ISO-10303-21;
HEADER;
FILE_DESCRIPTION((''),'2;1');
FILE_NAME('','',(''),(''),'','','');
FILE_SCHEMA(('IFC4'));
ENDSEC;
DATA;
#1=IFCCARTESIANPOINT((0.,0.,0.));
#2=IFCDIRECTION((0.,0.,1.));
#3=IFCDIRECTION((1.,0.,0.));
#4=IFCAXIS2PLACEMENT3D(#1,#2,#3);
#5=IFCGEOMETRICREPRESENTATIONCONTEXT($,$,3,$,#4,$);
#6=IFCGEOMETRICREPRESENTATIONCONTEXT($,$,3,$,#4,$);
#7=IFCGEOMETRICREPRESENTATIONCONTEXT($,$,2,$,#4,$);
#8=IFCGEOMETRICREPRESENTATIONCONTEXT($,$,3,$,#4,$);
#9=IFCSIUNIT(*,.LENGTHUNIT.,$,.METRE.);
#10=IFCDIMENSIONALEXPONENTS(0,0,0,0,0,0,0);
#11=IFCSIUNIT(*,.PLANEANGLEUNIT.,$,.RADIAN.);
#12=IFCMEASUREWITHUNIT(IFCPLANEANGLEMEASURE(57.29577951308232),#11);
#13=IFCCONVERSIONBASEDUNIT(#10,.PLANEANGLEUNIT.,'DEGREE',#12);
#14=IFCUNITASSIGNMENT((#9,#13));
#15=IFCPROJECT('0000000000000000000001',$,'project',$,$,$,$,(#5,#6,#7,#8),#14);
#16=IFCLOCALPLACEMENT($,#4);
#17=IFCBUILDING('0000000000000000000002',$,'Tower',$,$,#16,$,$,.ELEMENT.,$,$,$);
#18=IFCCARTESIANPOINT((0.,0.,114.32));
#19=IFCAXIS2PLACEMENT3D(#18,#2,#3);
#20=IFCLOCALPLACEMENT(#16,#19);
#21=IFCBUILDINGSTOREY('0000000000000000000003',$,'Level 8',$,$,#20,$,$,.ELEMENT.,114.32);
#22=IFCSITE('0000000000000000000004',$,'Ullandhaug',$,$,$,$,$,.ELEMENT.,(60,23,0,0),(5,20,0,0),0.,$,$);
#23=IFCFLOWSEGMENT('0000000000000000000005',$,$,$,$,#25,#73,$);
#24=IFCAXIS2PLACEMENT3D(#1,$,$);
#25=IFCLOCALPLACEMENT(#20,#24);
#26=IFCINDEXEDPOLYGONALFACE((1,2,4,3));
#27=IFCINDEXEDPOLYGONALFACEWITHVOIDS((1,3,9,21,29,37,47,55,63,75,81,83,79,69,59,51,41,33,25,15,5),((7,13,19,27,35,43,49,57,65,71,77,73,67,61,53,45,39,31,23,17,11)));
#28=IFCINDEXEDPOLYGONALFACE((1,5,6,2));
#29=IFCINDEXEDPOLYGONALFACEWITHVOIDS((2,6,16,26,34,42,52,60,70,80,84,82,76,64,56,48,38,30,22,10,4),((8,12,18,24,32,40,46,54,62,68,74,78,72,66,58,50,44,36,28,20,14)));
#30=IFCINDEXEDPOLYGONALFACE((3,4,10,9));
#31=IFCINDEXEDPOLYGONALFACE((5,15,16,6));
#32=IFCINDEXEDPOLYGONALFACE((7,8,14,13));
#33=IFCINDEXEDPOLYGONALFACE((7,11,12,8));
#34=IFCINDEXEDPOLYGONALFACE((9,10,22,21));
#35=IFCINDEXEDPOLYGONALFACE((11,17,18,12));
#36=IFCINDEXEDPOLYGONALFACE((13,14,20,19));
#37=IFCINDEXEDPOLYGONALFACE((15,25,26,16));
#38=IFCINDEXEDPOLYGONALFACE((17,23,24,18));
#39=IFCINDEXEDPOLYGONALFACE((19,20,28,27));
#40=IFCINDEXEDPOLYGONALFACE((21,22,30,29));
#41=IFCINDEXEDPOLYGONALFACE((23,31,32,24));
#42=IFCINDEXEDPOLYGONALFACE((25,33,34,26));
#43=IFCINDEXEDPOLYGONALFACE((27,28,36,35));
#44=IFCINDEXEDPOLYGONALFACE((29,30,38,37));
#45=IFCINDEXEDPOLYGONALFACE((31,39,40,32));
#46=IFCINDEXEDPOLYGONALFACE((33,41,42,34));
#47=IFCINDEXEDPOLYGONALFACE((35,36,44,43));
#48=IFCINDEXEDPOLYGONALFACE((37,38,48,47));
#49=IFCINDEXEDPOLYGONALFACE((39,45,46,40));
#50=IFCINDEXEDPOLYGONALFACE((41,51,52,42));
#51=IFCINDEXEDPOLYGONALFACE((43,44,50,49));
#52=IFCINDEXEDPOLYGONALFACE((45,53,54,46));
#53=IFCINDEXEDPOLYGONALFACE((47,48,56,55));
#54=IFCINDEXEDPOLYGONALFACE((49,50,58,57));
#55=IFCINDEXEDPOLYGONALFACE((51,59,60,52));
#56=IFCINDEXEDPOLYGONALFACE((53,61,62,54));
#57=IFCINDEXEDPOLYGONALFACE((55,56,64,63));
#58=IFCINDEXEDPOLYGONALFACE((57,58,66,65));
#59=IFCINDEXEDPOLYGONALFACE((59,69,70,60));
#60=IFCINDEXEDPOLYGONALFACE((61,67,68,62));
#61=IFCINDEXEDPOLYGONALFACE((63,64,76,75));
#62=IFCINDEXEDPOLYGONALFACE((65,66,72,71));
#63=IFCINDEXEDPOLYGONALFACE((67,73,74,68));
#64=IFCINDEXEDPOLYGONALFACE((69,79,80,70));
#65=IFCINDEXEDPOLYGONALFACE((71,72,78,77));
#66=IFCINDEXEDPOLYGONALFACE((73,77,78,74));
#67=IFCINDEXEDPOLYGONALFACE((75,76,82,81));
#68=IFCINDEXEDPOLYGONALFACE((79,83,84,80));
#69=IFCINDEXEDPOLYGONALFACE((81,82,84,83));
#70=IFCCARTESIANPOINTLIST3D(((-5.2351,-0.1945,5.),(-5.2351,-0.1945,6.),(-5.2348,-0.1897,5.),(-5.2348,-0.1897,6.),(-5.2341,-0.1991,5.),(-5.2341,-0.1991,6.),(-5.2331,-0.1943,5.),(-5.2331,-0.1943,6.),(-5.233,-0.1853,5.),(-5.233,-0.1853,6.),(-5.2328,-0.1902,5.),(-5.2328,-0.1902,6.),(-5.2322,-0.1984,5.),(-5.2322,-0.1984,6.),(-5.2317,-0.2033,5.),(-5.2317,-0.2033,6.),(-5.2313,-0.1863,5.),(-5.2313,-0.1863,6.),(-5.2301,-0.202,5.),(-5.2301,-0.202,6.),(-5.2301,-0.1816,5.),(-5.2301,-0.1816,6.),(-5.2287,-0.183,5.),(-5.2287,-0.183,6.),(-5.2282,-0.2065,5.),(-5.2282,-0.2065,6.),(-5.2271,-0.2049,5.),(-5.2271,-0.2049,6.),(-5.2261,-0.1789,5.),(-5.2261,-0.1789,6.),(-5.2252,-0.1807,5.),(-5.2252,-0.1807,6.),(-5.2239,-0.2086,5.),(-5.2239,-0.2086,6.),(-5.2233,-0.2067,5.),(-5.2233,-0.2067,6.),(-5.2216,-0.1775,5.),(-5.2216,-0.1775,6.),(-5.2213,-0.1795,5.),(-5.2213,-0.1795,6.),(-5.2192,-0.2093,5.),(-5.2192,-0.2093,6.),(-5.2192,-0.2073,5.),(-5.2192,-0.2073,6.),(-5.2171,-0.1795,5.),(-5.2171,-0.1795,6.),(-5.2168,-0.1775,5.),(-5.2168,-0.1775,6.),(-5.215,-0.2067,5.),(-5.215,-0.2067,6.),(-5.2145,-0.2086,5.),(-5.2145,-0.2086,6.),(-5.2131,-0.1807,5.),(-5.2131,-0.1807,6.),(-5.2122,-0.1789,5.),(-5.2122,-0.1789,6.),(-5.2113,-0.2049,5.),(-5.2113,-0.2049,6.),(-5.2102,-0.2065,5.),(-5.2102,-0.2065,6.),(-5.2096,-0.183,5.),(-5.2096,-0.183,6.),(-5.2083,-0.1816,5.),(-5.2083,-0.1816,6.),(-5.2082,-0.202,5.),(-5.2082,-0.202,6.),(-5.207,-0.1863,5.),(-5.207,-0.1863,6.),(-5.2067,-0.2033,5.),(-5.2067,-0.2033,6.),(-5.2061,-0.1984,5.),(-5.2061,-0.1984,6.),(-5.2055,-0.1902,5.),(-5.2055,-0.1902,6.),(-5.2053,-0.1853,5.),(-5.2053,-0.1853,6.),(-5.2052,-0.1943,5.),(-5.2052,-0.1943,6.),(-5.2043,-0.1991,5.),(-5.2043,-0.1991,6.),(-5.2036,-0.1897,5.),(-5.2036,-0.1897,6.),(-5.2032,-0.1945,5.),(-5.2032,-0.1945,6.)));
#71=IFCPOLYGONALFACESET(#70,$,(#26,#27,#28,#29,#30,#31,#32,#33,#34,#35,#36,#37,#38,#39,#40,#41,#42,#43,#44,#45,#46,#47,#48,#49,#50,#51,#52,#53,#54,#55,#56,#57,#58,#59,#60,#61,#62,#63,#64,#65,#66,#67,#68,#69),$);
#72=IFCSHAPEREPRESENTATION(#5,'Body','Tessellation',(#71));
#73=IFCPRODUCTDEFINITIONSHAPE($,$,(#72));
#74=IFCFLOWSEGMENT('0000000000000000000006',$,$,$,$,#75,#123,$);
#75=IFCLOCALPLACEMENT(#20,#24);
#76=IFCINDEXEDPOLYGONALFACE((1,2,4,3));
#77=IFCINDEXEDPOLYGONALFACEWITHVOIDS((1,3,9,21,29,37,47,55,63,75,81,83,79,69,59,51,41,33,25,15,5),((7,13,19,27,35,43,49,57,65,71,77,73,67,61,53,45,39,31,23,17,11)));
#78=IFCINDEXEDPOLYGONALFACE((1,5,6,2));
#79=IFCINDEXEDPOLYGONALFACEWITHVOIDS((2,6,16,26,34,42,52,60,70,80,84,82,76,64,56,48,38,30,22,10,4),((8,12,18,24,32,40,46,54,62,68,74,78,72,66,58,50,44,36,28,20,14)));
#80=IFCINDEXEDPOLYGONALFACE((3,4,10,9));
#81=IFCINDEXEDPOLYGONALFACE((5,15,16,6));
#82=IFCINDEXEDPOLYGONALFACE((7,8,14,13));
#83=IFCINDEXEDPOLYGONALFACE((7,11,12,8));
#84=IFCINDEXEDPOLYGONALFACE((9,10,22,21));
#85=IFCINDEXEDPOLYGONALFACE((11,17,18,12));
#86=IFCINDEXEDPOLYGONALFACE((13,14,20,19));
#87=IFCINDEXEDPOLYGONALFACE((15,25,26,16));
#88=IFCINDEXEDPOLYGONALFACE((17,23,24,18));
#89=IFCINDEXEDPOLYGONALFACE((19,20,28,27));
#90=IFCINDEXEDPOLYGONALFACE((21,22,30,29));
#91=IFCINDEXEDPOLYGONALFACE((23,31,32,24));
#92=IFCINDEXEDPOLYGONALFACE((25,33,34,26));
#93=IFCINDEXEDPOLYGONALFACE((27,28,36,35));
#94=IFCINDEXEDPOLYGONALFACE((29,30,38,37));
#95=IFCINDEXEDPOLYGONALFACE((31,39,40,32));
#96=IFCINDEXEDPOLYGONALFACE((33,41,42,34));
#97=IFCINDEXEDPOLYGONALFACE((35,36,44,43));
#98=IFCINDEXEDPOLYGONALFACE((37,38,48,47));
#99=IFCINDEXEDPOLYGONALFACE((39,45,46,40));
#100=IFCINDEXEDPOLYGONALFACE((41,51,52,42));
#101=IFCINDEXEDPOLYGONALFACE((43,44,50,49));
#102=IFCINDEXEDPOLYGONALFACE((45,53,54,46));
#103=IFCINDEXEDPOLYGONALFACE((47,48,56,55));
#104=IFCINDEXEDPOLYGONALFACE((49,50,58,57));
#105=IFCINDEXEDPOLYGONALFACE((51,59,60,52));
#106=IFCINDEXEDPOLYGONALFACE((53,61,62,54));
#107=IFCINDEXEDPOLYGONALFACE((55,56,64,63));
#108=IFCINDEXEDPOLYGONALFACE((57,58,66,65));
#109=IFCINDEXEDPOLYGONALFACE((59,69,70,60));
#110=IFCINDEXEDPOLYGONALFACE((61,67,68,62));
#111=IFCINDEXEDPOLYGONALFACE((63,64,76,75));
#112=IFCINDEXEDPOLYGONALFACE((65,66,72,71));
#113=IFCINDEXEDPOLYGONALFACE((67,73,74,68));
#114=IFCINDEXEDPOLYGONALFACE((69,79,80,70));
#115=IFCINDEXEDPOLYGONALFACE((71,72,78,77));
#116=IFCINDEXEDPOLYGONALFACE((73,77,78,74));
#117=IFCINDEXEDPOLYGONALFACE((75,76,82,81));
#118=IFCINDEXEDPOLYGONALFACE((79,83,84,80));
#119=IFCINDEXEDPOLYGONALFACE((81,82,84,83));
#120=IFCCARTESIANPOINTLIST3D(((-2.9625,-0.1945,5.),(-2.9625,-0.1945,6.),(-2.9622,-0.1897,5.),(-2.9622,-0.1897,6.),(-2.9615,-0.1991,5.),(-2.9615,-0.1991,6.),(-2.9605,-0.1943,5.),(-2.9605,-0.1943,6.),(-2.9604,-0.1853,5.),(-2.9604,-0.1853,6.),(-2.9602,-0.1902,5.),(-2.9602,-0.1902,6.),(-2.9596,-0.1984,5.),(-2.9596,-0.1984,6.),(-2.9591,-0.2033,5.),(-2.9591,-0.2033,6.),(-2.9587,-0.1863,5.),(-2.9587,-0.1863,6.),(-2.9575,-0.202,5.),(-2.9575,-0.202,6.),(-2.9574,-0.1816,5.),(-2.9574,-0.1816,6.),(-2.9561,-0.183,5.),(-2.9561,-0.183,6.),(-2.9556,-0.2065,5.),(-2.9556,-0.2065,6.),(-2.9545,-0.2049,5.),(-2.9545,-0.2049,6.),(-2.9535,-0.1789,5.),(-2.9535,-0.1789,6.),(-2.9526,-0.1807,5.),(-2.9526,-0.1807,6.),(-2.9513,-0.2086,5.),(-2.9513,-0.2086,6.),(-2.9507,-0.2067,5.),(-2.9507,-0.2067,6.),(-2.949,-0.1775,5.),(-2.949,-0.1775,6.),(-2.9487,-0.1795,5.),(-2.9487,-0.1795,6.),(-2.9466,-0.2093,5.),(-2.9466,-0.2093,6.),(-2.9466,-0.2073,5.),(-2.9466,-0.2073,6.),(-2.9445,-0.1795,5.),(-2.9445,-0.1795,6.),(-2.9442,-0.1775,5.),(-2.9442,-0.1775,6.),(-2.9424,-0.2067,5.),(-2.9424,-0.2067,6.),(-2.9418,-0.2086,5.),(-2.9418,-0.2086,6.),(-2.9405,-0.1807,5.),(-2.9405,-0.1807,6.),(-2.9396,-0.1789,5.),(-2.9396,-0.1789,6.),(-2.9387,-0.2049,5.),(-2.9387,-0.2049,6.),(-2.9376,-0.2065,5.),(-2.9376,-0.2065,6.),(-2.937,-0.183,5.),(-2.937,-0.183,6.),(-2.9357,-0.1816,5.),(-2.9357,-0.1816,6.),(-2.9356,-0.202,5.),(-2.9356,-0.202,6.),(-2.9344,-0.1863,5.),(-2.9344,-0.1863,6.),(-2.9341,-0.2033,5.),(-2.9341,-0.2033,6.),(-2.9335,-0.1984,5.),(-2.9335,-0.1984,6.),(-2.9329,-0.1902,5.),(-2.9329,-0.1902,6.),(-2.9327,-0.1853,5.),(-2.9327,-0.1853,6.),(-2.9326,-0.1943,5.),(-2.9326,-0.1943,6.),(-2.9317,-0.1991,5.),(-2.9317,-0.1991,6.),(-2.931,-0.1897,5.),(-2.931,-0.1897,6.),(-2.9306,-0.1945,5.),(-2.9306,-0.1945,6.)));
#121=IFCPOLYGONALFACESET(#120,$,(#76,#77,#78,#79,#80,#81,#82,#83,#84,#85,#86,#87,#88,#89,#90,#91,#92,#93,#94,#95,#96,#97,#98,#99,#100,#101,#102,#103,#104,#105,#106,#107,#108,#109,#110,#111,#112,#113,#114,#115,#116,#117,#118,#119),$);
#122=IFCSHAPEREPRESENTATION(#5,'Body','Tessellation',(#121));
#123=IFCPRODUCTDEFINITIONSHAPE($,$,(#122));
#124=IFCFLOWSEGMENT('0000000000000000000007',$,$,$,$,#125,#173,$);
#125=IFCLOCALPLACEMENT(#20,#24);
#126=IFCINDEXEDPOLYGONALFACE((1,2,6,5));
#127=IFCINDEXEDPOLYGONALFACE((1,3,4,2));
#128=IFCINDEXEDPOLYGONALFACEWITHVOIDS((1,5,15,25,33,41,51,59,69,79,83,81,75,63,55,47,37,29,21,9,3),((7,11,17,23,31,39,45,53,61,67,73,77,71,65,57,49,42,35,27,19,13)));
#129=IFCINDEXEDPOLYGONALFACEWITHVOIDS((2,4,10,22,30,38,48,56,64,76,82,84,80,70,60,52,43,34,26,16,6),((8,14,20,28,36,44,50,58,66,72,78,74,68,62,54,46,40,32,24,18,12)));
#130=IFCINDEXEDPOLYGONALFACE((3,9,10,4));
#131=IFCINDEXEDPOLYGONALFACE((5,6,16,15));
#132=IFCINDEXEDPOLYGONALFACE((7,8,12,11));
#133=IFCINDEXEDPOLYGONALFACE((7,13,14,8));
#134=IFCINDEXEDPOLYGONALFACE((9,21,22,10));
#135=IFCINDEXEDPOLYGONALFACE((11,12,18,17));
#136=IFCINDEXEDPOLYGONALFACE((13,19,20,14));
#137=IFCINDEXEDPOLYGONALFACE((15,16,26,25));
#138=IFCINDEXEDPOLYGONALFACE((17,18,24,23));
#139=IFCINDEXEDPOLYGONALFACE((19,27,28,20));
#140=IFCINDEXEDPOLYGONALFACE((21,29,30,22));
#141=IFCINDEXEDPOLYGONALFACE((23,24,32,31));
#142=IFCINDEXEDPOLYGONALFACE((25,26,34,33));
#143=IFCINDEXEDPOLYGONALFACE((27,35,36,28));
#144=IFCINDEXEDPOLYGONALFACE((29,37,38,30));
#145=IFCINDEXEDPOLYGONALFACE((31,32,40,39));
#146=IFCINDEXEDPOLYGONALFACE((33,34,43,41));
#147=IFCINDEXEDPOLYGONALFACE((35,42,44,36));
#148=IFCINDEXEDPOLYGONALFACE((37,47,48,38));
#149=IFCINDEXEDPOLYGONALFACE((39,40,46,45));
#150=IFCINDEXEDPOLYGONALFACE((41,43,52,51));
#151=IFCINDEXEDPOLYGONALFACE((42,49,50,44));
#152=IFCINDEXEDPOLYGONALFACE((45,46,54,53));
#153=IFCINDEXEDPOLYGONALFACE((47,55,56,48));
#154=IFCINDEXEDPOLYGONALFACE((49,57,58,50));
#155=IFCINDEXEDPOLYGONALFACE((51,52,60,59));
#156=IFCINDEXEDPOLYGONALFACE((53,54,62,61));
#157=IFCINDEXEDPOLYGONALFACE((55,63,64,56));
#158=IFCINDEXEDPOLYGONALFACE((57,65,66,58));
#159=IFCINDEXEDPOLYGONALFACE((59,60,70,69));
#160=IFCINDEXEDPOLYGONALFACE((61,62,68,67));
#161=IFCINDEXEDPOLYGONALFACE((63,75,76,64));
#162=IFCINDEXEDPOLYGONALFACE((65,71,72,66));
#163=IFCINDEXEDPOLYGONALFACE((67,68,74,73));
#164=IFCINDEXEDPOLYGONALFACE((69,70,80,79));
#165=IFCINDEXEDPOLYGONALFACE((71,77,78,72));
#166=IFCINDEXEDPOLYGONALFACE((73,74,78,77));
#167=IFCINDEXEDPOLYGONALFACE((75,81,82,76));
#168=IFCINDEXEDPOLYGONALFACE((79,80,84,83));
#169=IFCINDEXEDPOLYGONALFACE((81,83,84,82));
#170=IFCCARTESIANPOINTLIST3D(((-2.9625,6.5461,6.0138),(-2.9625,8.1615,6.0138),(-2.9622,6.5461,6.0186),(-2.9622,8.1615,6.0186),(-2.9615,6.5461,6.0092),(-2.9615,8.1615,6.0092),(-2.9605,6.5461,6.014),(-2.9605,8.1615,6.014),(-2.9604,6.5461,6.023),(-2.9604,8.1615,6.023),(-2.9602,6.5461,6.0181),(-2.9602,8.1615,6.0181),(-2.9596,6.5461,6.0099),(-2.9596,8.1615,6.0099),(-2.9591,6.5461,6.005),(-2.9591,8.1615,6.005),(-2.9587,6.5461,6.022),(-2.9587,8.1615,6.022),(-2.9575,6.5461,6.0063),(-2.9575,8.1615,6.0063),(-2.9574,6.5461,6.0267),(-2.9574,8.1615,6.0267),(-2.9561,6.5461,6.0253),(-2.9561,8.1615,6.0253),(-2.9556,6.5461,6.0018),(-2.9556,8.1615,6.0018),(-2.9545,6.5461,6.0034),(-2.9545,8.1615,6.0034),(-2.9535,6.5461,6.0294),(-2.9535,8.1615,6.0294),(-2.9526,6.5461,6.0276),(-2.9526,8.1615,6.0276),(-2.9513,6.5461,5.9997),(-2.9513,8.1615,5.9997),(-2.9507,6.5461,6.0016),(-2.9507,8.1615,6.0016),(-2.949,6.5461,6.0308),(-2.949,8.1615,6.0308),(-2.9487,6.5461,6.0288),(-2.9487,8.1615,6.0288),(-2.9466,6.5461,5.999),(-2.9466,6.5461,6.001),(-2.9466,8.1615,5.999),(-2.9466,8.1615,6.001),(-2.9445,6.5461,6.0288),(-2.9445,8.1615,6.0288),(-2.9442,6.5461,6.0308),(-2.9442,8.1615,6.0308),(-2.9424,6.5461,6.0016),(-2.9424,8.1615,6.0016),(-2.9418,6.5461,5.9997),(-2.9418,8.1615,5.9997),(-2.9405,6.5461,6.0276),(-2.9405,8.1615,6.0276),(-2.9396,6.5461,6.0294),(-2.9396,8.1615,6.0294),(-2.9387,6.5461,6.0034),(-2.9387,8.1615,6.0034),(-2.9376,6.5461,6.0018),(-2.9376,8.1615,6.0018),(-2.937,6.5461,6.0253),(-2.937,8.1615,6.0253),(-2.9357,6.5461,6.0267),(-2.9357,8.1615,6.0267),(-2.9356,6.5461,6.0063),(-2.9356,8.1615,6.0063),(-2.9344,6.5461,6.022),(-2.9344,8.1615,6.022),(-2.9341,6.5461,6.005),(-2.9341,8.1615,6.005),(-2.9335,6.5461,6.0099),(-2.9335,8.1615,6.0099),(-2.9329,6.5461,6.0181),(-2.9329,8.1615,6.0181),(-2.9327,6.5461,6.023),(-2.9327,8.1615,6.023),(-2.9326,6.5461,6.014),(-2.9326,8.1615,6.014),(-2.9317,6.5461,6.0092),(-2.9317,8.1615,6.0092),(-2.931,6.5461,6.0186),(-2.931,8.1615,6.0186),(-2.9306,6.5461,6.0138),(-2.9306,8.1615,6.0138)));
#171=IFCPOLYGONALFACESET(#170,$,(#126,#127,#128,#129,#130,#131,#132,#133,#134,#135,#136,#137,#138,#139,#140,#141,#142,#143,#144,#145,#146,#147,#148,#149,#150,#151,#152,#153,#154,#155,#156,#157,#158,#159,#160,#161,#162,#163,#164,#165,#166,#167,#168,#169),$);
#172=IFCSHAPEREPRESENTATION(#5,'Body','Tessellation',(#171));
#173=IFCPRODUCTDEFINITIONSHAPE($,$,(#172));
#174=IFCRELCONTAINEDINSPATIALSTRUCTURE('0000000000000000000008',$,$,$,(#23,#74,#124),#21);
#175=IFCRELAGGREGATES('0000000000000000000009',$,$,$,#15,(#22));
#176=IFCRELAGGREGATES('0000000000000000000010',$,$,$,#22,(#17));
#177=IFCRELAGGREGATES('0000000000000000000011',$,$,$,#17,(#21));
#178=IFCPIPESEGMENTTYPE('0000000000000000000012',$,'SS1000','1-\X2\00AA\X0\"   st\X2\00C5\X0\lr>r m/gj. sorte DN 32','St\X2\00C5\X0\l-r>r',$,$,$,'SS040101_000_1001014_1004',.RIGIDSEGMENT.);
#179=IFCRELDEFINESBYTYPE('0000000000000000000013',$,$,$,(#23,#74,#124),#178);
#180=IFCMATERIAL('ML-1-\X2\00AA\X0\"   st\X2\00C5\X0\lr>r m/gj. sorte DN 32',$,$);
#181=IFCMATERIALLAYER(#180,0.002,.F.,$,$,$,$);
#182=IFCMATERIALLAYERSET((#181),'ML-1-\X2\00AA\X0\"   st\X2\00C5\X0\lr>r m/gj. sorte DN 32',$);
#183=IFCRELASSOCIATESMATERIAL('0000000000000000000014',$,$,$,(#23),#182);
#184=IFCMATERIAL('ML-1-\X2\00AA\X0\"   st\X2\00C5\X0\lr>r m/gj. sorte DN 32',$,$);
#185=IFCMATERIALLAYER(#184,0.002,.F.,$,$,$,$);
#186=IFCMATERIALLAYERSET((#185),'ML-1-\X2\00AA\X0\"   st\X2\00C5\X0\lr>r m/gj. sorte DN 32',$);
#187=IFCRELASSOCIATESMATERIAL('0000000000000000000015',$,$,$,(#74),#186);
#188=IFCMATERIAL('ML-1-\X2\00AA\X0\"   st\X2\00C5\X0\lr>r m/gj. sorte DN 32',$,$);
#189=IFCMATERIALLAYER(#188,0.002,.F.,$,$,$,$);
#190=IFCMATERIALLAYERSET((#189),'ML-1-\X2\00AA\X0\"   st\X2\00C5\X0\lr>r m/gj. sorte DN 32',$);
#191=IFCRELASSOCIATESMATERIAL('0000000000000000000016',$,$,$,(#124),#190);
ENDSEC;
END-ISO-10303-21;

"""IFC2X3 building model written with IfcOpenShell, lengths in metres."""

from ifc_helpers import new_model, entity, si_unit, converted_unit, frame, origin_with_axes, origin_2d_with_axis, place, context, project, spatial, hollow_circle, extrude, material, layer, layer_set, layer_usage, type_object, element, save


model = new_model("IFC2X3")

# Units and contexts
context_of_model_1 = context(None, 3, world=origin_with_axes())
context_of_model_2 = context(None, 3, world=origin_with_axes())
context_of_model_3 = context(None, 2, world=origin_with_axes())
context_of_model_4 = context(None, 3, world=origin_with_axes())
ifc_project = project(units=[si_unit("LENGTHUNIT", "METRE"), converted_unit("PLANEANGLEUNIT", "DEGREE", entity("IfcPlaneAngleMeasure", 57.29577951308232), si_unit("PLANEANGLEUNIT", "RADIAN"), dimensions=[0, 0, 0, 0, 0, 0, 0])], contexts=[context_of_model_1, context_of_model_2, context_of_model_3, context_of_model_4])

# Site, building, storey
site = spatial("IfcSite", under=ifc_project, Name="Ullandhaug", CompositionType="ELEMENT", RefLatitude=(60, 23, 0, 0), RefLongitude=(5, 20, 0, 0), RefElevation=0.0)
building_placement = place(None, origin_with_axes())
building = spatial("IfcBuilding", under=site, at=building_placement, Name="Tower", CompositionType="ELEMENT")
storey_placement = place(building_placement, frame((0.0, 0.0, 114.32), z_axis=(0.0, 0.0, 1.0), x_axis=(1.0, 0.0, 0.0)))
storey = spatial("IfcBuildingStorey", under=building, at=storey_placement, Name="Level 8", CompositionType="ELEMENT", Elevation=114.32)

# Flow segments
pipe_segment_type_1 = type_object("IfcPipeSegmentType", Name="SS1000", Description="1-ª\"   stÅlr>r m/gj. sorte DN 32", ApplicableOccurrence="StÅl-r>r", ElementType="SS040101_000_1001014_1004", PredefinedType="RIGIDSEGMENT")
ifc_material_1 = material(Name="ML-1-ª\"   stÅlr>r m/gj. sorte DN 32")
ifc_layer_1 = layer(ifc_material_1, 0.002, ventilated=False)
ifc_layer_set_1 = layer_set([ifc_layer_1], Name="ML-1-ª\"   stÅlr>r m/gj. sorte DN 32")
ifc_layer_usage_1 = layer_usage(ifc_layer_set_1, "AXIS2", "POSITIVE", 0.0)
flow_segment_1_placement = place(storey_placement, frame((-5.2192, -0.1933, 5.0), z_axis=(0.0, 0.0, 1.0), x_axis=(0.0, -1.0, 0.0)))
element("IfcFlowSegment", 1, at=flow_segment_1_placement, inside=storey, type_object=pipe_segment_type_1, material=ifc_layer_usage_1, context=context_of_model_1, shape_type="SweptSolid", body=[
    extrude(hollow_circle(Radius=0.016, WallThickness=0.002, at=origin_2d_with_axis()), origin_with_axes(), (0.0, 0.0, 1.0), 1.0),
])
ifc_material_2 = material(Name="ML-1-ª\"   stÅlr>r m/gj. sorte DN 32")
ifc_layer_2 = layer(ifc_material_2, 0.002, ventilated=False)
ifc_layer_set_2 = layer_set([ifc_layer_2], Name="ML-1-ª\"   stÅlr>r m/gj. sorte DN 32")
ifc_layer_usage_2 = layer_usage(ifc_layer_set_2, "AXIS2", "POSITIVE", 0.0)
flow_segment_2_placement = place(storey_placement, frame((-2.9466, -0.1933, 5.0), z_axis=(0.0, 0.0, 1.0), x_axis=(0.0, -1.0, 0.0)))
element("IfcFlowSegment", 2, at=flow_segment_2_placement, inside=storey, type_object=pipe_segment_type_1, material=ifc_layer_usage_2, context=context_of_model_1, shape_type="SweptSolid", body=[
    extrude(hollow_circle(Radius=0.016, WallThickness=0.002, at=origin_2d_with_axis()), origin_with_axes(), (0.0, 0.0, 1.0), 1.0),
])
ifc_material_3 = material(Name="ML-1-ª\"   stÅlr>r m/gj. sorte DN 32")
ifc_layer_3 = layer(ifc_material_3, 0.002, ventilated=False)
ifc_layer_set_3 = layer_set([ifc_layer_3], Name="ML-1-ª\"   stÅlr>r m/gj. sorte DN 32")
ifc_layer_usage_3 = layer_usage(ifc_layer_set_3, "AXIS2", "POSITIVE", 0.0)
flow_segment_3_placement = place(storey_placement, frame((-2.9466, 6.5461, 6.015), z_axis=(0.0, 1.0, 0.0), x_axis=(0.0, 0.0, -1.0)))
element("IfcFlowSegment", 3, at=flow_segment_3_placement, inside=storey, type_object=pipe_segment_type_1, material=ifc_layer_usage_3, context=context_of_model_1, shape_type="SweptSolid", body=[
    extrude(hollow_circle(Radius=0.016, WallThickness=0.002, at=origin_2d_with_axis()), origin_with_axes(), (0.0, 0.0, 1.0), 1.6154),
])

save(model, "model.ifc")
